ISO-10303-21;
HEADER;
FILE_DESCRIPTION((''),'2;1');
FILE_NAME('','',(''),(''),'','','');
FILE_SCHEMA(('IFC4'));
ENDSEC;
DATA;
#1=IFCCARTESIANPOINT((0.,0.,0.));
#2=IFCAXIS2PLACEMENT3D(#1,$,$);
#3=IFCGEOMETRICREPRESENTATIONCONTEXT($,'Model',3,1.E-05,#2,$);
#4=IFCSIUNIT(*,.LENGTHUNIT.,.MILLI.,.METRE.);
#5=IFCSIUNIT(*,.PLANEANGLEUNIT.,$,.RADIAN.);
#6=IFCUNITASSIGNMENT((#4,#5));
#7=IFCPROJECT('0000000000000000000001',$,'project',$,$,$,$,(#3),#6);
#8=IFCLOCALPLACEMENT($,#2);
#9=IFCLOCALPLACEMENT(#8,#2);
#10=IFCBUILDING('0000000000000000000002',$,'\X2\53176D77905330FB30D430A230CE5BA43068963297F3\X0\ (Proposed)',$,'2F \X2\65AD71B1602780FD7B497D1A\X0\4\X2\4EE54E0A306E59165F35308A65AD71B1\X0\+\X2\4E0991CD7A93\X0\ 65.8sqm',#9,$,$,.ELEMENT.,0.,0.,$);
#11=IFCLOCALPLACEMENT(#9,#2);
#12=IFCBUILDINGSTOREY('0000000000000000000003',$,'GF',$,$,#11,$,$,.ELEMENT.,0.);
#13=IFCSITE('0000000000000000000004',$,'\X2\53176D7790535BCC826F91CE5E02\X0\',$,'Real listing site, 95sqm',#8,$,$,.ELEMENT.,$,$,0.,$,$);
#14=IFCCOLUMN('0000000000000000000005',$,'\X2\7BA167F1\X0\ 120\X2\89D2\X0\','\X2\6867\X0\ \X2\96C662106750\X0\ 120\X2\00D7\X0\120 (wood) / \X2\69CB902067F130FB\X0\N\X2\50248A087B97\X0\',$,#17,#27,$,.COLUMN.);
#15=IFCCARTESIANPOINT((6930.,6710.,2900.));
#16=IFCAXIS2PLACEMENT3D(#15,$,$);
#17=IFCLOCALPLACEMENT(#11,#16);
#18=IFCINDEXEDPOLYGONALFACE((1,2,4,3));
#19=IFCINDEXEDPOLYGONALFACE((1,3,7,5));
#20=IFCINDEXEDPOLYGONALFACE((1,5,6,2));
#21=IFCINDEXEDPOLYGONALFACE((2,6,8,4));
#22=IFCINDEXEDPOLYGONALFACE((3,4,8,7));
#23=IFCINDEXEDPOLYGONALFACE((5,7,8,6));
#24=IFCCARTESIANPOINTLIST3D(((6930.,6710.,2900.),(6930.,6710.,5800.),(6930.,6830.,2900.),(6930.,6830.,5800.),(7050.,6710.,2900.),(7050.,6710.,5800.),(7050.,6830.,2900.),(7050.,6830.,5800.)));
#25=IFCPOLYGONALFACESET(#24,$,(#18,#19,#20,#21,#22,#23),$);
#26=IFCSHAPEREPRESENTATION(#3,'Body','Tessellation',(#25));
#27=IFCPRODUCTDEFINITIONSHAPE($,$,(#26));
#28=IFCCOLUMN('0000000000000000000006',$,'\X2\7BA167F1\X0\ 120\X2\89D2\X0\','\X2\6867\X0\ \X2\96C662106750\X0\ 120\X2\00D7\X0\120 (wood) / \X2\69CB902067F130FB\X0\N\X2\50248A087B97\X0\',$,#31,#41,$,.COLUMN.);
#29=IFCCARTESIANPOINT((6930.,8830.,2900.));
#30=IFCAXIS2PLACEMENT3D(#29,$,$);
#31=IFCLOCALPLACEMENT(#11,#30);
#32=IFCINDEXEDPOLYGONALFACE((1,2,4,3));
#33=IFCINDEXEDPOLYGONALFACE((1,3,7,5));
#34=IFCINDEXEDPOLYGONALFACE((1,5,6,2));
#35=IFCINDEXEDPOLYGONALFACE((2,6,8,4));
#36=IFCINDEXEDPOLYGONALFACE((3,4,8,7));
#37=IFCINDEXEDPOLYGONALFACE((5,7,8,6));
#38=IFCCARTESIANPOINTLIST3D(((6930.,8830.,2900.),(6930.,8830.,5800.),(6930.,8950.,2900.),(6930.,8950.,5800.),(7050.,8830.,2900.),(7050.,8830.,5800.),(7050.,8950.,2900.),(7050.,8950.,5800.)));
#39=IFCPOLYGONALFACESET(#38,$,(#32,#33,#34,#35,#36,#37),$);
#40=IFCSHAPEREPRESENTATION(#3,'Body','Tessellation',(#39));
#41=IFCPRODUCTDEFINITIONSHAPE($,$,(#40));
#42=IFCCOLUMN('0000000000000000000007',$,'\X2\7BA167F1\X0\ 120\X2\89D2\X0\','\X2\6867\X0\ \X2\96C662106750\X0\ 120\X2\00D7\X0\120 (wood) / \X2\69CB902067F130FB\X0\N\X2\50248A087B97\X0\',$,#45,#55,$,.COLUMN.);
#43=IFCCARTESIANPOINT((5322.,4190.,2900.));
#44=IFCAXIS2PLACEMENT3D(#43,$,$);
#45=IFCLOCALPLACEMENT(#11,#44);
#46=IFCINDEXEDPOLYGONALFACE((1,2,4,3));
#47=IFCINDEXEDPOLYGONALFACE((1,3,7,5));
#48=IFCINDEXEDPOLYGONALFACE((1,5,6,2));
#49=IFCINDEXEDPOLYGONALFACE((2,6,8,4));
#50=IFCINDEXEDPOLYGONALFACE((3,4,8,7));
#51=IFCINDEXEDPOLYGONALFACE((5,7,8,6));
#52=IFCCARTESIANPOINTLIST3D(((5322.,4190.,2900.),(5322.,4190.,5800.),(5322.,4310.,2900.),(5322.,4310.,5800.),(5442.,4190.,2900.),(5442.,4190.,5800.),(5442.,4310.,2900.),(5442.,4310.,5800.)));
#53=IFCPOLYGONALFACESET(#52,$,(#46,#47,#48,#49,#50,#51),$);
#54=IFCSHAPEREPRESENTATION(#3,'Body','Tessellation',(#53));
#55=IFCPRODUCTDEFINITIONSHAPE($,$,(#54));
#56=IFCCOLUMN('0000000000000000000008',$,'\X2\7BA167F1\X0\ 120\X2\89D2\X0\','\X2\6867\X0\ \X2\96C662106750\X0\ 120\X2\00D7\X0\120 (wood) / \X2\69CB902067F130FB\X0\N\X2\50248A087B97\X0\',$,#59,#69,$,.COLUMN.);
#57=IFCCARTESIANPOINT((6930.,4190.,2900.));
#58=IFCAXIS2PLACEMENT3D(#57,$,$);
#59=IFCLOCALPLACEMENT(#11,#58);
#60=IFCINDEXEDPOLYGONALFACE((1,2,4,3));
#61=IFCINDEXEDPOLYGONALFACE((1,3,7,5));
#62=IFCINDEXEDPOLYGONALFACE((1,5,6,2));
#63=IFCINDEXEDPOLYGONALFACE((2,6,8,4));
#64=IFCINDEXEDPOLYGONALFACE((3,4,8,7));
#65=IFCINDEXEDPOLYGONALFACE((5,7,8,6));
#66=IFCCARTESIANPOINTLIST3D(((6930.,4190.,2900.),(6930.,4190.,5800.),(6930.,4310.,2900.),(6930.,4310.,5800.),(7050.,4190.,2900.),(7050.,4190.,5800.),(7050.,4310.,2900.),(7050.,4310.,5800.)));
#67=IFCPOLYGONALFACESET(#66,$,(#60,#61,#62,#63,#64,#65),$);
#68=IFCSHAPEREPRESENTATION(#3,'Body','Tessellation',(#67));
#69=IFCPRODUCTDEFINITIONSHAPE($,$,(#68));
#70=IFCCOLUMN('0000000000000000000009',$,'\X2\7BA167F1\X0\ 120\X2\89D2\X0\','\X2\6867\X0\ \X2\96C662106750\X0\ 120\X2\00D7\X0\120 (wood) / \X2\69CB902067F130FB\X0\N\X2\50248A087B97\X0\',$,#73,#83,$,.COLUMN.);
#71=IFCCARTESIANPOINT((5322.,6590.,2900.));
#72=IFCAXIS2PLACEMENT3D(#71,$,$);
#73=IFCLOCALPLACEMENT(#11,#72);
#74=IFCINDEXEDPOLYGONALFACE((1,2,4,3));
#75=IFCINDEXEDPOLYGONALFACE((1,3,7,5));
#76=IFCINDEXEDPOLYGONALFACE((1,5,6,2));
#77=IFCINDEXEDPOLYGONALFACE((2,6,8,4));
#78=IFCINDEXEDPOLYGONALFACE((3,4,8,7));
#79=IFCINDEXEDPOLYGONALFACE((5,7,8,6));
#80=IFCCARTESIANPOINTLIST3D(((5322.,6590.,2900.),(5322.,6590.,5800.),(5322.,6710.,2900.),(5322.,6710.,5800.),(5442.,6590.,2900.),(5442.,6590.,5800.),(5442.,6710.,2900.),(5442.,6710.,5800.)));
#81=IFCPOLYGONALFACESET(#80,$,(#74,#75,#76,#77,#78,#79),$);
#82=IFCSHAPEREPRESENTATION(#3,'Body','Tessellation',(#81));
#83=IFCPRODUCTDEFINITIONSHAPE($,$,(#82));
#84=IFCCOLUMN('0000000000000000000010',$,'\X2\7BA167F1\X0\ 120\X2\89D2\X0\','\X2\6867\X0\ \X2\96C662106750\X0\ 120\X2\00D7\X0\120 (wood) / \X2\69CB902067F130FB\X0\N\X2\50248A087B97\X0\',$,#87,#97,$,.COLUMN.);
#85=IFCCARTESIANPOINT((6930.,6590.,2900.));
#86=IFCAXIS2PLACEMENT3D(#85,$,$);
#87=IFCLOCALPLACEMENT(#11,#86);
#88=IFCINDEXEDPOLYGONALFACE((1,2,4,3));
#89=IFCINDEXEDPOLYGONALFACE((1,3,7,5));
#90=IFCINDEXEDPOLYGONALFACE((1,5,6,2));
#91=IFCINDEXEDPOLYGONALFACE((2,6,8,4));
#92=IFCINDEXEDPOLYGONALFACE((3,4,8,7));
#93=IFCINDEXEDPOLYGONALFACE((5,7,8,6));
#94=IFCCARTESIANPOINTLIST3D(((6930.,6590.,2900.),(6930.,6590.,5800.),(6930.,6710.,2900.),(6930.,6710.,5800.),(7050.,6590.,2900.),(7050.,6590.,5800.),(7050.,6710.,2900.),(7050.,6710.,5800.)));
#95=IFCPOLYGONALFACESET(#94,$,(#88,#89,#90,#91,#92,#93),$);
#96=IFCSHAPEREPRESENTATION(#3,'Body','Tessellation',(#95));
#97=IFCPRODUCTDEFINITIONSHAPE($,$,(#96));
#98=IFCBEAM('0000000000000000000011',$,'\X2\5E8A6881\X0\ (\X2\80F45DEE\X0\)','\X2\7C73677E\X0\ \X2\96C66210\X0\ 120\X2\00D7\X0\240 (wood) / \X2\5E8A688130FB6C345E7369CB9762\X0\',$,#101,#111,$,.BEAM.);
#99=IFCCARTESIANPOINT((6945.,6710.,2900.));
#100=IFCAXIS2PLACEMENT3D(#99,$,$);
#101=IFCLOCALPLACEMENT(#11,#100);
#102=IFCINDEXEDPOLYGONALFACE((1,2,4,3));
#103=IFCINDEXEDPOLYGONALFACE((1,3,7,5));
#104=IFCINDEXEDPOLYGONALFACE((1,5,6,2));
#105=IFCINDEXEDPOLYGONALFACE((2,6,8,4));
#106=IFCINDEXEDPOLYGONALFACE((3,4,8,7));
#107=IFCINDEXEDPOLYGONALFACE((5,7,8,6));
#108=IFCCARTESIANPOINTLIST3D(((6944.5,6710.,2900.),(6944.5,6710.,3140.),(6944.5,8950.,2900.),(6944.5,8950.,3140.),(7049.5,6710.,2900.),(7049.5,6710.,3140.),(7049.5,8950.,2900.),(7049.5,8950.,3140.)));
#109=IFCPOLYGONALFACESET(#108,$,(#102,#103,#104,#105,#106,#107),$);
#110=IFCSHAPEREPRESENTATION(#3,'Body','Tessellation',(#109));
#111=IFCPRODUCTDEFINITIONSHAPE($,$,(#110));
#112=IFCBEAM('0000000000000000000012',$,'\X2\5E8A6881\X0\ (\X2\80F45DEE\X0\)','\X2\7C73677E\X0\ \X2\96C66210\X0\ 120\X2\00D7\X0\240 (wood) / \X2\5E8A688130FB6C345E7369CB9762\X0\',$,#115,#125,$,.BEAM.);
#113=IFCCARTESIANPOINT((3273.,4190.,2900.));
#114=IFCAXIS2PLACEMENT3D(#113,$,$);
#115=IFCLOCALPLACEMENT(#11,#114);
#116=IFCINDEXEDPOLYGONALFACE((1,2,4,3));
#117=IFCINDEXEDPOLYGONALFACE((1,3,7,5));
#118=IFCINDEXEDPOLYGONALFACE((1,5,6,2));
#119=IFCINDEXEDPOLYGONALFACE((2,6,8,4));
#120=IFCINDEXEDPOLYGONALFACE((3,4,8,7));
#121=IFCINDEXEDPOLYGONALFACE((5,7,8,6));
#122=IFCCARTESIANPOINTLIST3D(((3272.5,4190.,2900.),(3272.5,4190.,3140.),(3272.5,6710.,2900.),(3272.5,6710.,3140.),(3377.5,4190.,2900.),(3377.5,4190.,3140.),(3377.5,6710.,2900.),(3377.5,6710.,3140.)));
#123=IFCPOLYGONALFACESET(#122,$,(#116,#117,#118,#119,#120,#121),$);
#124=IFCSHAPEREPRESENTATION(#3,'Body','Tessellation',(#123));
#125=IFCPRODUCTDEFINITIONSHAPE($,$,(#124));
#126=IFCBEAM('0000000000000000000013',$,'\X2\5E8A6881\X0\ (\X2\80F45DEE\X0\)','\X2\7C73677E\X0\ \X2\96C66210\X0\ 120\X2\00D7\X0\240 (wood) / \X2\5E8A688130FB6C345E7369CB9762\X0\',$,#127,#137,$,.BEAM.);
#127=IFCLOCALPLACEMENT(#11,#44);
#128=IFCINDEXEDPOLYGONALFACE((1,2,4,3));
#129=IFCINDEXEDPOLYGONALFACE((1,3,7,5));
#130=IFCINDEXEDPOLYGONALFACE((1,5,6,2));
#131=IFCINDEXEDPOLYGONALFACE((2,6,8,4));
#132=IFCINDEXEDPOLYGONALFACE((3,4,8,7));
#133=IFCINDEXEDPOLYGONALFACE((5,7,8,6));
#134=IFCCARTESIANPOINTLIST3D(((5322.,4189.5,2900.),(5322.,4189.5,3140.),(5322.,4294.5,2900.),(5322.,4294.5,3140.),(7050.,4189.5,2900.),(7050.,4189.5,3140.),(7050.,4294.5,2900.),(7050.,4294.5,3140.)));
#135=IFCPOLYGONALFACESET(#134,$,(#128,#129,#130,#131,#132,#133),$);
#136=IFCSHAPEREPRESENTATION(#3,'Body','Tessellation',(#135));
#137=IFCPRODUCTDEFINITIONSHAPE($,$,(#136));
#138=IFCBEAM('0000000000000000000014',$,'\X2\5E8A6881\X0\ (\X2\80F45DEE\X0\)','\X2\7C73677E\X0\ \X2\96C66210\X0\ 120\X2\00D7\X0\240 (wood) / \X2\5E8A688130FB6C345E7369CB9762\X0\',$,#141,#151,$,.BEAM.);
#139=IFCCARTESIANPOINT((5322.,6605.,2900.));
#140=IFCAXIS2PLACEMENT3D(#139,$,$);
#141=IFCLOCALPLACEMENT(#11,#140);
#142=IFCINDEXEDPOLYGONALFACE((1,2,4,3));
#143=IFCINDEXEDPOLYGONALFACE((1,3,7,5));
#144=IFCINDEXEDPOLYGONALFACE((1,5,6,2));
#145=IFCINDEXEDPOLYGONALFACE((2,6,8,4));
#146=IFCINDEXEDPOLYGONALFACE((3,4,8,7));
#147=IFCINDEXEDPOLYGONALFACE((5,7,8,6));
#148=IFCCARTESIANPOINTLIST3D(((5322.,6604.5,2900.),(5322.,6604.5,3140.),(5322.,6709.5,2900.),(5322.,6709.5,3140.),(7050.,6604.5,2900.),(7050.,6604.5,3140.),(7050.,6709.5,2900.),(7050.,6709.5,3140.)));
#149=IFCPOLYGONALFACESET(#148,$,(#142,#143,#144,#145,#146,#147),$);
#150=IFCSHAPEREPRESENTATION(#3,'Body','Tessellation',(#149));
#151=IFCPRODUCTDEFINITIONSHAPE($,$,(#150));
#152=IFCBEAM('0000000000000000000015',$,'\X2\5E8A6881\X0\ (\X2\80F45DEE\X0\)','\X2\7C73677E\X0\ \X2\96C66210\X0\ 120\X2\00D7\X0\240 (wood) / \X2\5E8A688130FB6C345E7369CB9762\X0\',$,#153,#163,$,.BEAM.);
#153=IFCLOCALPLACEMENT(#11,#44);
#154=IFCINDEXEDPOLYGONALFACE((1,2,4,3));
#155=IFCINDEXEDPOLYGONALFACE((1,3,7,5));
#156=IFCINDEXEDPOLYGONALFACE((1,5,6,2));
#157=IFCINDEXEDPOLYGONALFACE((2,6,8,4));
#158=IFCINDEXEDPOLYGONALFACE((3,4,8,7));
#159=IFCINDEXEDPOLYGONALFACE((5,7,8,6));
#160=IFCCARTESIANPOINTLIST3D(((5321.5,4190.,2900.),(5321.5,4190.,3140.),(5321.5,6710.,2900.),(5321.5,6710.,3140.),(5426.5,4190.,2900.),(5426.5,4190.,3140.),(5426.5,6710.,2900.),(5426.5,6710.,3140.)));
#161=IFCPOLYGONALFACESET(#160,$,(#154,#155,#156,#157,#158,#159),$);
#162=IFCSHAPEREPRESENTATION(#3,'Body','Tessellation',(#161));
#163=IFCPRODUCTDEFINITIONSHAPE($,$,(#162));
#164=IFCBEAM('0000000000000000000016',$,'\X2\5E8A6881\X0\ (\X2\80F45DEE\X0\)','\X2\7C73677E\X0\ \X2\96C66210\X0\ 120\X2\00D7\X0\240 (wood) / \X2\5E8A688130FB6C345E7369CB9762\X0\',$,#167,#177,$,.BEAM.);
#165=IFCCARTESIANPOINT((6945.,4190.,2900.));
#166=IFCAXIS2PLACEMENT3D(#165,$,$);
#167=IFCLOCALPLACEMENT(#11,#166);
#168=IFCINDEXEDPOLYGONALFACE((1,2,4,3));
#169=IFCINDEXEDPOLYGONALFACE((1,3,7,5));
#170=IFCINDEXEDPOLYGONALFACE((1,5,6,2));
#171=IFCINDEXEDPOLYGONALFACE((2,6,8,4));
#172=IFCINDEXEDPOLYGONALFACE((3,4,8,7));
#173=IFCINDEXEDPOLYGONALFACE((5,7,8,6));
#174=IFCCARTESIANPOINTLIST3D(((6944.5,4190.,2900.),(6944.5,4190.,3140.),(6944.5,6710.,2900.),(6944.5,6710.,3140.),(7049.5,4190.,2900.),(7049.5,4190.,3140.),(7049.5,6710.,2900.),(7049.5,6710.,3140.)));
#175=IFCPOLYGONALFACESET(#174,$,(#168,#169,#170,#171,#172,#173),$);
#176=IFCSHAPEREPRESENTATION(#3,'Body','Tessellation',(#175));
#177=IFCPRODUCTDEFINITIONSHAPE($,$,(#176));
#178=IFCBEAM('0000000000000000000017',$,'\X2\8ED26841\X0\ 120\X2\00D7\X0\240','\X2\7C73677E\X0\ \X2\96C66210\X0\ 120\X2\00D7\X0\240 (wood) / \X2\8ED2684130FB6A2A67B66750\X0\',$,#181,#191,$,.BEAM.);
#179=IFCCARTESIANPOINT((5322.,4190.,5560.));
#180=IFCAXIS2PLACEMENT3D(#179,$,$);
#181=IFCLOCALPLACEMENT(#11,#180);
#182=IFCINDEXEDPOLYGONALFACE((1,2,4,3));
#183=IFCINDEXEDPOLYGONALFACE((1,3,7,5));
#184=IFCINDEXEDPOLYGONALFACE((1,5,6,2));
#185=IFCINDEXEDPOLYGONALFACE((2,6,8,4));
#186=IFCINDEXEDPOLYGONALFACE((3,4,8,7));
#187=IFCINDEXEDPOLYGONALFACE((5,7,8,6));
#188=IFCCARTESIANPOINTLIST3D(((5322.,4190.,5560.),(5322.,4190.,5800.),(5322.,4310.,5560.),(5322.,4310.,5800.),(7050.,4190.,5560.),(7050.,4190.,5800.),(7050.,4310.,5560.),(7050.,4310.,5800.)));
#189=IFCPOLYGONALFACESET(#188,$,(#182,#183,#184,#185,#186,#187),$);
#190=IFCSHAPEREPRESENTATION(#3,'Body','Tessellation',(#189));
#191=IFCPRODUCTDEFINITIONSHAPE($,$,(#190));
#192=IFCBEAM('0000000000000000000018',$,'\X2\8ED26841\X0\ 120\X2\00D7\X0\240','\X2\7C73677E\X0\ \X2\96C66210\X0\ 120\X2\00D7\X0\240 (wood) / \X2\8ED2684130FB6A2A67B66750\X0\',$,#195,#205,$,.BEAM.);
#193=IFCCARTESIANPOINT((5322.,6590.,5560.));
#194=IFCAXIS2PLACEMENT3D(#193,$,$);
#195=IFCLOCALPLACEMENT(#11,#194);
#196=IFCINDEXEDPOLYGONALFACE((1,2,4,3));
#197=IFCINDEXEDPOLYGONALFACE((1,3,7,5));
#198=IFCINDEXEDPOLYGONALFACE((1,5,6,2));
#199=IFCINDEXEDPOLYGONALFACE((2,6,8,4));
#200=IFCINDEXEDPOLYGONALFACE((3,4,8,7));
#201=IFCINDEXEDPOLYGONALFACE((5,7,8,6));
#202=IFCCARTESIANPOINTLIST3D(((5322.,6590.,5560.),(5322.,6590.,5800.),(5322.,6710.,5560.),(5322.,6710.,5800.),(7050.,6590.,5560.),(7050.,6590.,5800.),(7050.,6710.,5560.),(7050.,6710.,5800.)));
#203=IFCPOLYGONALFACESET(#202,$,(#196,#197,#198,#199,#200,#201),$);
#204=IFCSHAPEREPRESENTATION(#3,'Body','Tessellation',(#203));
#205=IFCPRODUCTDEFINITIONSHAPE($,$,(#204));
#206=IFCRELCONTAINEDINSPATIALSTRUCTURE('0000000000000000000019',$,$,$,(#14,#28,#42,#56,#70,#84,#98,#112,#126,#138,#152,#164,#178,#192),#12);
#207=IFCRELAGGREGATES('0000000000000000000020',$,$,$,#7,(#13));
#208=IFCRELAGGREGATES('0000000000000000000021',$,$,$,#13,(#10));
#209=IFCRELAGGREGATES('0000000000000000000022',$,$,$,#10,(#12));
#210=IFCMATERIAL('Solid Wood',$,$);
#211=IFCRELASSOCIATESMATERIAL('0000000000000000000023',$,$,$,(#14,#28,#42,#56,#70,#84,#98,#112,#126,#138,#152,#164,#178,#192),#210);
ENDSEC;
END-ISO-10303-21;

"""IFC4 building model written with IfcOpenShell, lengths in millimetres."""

from ifc_helpers import new_model, si_unit, frame, frame_2d, origin, place, context, project, spatial, rectangle, extrude, material, element, save


model = new_model("IFC4")

# Units and contexts
model_context = context("Model", 3, precision=1e-05, world=origin())
ifc_project = project(units=[si_unit("LENGTHUNIT", "METRE", prefix="MILLI"), si_unit("PLANEANGLEUNIT", "RADIAN")], contexts=[model_context])

# Site, building, storey
site_placement = place(None, origin())
site = spatial("IfcSite", under=ifc_project, at=site_placement, Name="北海道富良野市", ObjectType="Real listing site, 95sqm", CompositionType="ELEMENT", RefElevation=0.0)
building_placement = place(site_placement, origin())
building = spatial("IfcBuilding", under=site, at=building_placement, Name="北海道・ピアノ室と防音 (Proposed)", ObjectType="2F 断熱性能等級4以上の外張り断熱+三重窓 65.8sqm", CompositionType="ELEMENT", ElevationOfRefHeight=0.0, ElevationOfTerrain=0.0)
storey_placement = place(building_placement, origin())
storey = spatial("IfcBuildingStorey", under=building, at=storey_placement, Name="GF", CompositionType="ELEMENT", Elevation=0.0)

# Columns
ifc_material_1 = material(Name="Solid Wood")
column_1_placement = place(storey_placement, frame((6930.0, 6710.0, 2900.0)))
element("IfcColumn", 1, at=column_1_placement, inside=storey, material=ifc_material_1, Name="管柱 120角", Description="桧 集成材 120×120 (wood) / 構造柱・N値計算", PredefinedType="COLUMN", context=model_context, shape_type="SweptSolid", body=[
    extrude(rectangle(XDim=120.0, YDim=120.0, at=frame_2d((60.0, 60.0))), frame((6930.0, 6710.0, 2900.0)), (0.0, 0.0, 1.0), 2900.0),
])
column_2_placement = place(storey_placement, frame((6930.0, 8830.0, 2900.0)))
element("IfcColumn", 2, at=column_2_placement, inside=storey, material=ifc_material_1, Name="管柱 120角", Description="桧 集成材 120×120 (wood) / 構造柱・N値計算", PredefinedType="COLUMN", context=model_context, shape_type="SweptSolid", body=[
    extrude(rectangle(XDim=120.0, YDim=120.0, at=frame_2d((60.0, 60.0))), frame((6930.0, 8830.0, 2900.0)), (0.0, 0.0, 1.0), 2900.0),
])
column_3_placement = place(storey_placement, frame((5322.0, 4190.0, 2900.0)))
element("IfcColumn", 3, at=column_3_placement, inside=storey, material=ifc_material_1, Name="管柱 120角", Description="桧 集成材 120×120 (wood) / 構造柱・N値計算", PredefinedType="COLUMN", context=model_context, shape_type="SweptSolid", body=[
    extrude(rectangle(XDim=120.0, YDim=120.0, at=frame_2d((60.0, 60.0))), frame((5322.0, 4190.0, 2900.0)), (0.0, 0.0, 1.0), 2900.0),
])
column_4_placement = place(storey_placement, frame((6930.0, 4190.0, 2900.0)))
element("IfcColumn", 4, at=column_4_placement, inside=storey, material=ifc_material_1, Name="管柱 120角", Description="桧 集成材 120×120 (wood) / 構造柱・N値計算", PredefinedType="COLUMN", context=model_context, shape_type="SweptSolid", body=[
    extrude(rectangle(XDim=120.0, YDim=120.0, at=frame_2d((60.0, 60.0))), frame((6930.0, 4190.0, 2900.0)), (0.0, 0.0, 1.0), 2900.0),
])
column_5_placement = place(storey_placement, frame((5322.0, 6590.0, 2900.0)))
element("IfcColumn", 5, at=column_5_placement, inside=storey, material=ifc_material_1, Name="管柱 120角", Description="桧 集成材 120×120 (wood) / 構造柱・N値計算", PredefinedType="COLUMN", context=model_context, shape_type="SweptSolid", body=[
    extrude(rectangle(XDim=120.0, YDim=120.0, at=frame_2d((60.0, 60.0))), frame((5322.0, 6590.0, 2900.0)), (0.0, 0.0, 1.0), 2900.0),
])
column_6_placement = place(storey_placement, frame((6930.0, 6590.0, 2900.0)))
element("IfcColumn", 6, at=column_6_placement, inside=storey, material=ifc_material_1, Name="管柱 120角", Description="桧 集成材 120×120 (wood) / 構造柱・N値計算", PredefinedType="COLUMN", context=model_context, shape_type="SweptSolid", body=[
    extrude(rectangle(XDim=120.0, YDim=120.0, at=frame_2d((60.0, 60.0))), frame((6930.0, 6590.0, 2900.0)), (0.0, 0.0, 1.0), 2900.0),
])

# Beams
beam_1_placement = place(storey_placement, frame((6945.0, 6710.0, 2900.0)))
element("IfcBeam", 7, at=beam_1_placement, inside=storey, material=ifc_material_1, Name="床梁 (胴差)", Description="米松 集成 120×240 (wood) / 床梁・水平構面", PredefinedType="BEAM", context=model_context, shape_type="SweptSolid", body=[
    extrude(rectangle(XDim=105.0, YDim=2240.0, at=frame_2d((52.0, 1120.0))), frame((6945.0, 6710.0, 2900.0)), (0.0, 0.0, 1.0), 240.0),
])
beam_2_placement = place(storey_placement, frame((3273.0, 4190.0, 2900.0)))
element("IfcBeam", 8, at=beam_2_placement, inside=storey, material=ifc_material_1, Name="床梁 (胴差)", Description="米松 集成 120×240 (wood) / 床梁・水平構面", PredefinedType="BEAM", context=model_context, shape_type="SweptSolid", body=[
    extrude(rectangle(XDim=105.0, YDim=2520.0, at=frame_2d((52.0, 1260.0))), frame((3273.0, 4190.0, 2900.0)), (0.0, 0.0, 1.0), 240.0),
])
beam_3_placement = place(storey_placement, frame((5322.0, 4190.0, 2900.0)))
element("IfcBeam", 9, at=beam_3_placement, inside=storey, material=ifc_material_1, Name="床梁 (胴差)", Description="米松 集成 120×240 (wood) / 床梁・水平構面", PredefinedType="BEAM", context=model_context, shape_type="SweptSolid", body=[
    extrude(rectangle(XDim=1728.0, YDim=105.0, at=frame_2d((864.0, 52.0))), frame((5322.0, 4190.0, 2900.0)), (0.0, 0.0, 1.0), 240.0),
])
beam_4_placement = place(storey_placement, frame((5322.0, 6605.0, 2900.0)))
element("IfcBeam", 10, at=beam_4_placement, inside=storey, material=ifc_material_1, Name="床梁 (胴差)", Description="米松 集成 120×240 (wood) / 床梁・水平構面", PredefinedType="BEAM", context=model_context, shape_type="SweptSolid", body=[
    extrude(rectangle(XDim=1728.0, YDim=105.0, at=frame_2d((864.0, 52.0))), frame((5322.0, 6605.0, 2900.0)), (0.0, 0.0, 1.0), 240.0),
])
beam_5_placement = place(storey_placement, frame((5322.0, 4190.0, 2900.0)))
element("IfcBeam", 11, at=beam_5_placement, inside=storey, material=ifc_material_1, Name="床梁 (胴差)", Description="米松 集成 120×240 (wood) / 床梁・水平構面", PredefinedType="BEAM", context=model_context, shape_type="SweptSolid", body=[
    extrude(rectangle(XDim=105.0, YDim=2520.0, at=frame_2d((52.0, 1260.0))), frame((5322.0, 4190.0, 2900.0)), (0.0, 0.0, 1.0), 240.0),
])
beam_6_placement = place(storey_placement, frame((6945.0, 4190.0, 2900.0)))
element("IfcBeam", 12, at=beam_6_placement, inside=storey, material=ifc_material_1, Name="床梁 (胴差)", Description="米松 集成 120×240 (wood) / 床梁・水平構面", PredefinedType="BEAM", context=model_context, shape_type="SweptSolid", body=[
    extrude(rectangle(XDim=105.0, YDim=2520.0, at=frame_2d((52.0, 1260.0))), frame((6945.0, 4190.0, 2900.0)), (0.0, 0.0, 1.0), 240.0),
])
beam_7_placement = place(storey_placement, frame((5322.0, 4190.0, 5560.0)))
element("IfcBeam", 13, at=beam_7_placement, inside=storey, material=ifc_material_1, Name="軒桁 120×240", Description="米松 集成 120×240 (wood) / 軒桁・横架材", PredefinedType="BEAM", context=model_context, shape_type="SweptSolid", body=[
    extrude(rectangle(XDim=1728.0, YDim=120.0, at=frame_2d((864.0, 60.0))), frame((5322.0, 4190.0, 5560.0)), (0.0, 0.0, 1.0), 240.0),
])
beam_8_placement = place(storey_placement, frame((5322.0, 6590.0, 5560.0)))
element("IfcBeam", 14, at=beam_8_placement, inside=storey, material=ifc_material_1, Name="軒桁 120×240", Description="米松 集成 120×240 (wood) / 軒桁・横架材", PredefinedType="BEAM", context=model_context, shape_type="SweptSolid", body=[
    extrude(rectangle(XDim=1728.0, YDim=120.0, at=frame_2d((864.0, 60.0))), frame((5322.0, 6590.0, 5560.0)), (0.0, 0.0, 1.0), 240.0),
])

save(model, "model.ifc")
